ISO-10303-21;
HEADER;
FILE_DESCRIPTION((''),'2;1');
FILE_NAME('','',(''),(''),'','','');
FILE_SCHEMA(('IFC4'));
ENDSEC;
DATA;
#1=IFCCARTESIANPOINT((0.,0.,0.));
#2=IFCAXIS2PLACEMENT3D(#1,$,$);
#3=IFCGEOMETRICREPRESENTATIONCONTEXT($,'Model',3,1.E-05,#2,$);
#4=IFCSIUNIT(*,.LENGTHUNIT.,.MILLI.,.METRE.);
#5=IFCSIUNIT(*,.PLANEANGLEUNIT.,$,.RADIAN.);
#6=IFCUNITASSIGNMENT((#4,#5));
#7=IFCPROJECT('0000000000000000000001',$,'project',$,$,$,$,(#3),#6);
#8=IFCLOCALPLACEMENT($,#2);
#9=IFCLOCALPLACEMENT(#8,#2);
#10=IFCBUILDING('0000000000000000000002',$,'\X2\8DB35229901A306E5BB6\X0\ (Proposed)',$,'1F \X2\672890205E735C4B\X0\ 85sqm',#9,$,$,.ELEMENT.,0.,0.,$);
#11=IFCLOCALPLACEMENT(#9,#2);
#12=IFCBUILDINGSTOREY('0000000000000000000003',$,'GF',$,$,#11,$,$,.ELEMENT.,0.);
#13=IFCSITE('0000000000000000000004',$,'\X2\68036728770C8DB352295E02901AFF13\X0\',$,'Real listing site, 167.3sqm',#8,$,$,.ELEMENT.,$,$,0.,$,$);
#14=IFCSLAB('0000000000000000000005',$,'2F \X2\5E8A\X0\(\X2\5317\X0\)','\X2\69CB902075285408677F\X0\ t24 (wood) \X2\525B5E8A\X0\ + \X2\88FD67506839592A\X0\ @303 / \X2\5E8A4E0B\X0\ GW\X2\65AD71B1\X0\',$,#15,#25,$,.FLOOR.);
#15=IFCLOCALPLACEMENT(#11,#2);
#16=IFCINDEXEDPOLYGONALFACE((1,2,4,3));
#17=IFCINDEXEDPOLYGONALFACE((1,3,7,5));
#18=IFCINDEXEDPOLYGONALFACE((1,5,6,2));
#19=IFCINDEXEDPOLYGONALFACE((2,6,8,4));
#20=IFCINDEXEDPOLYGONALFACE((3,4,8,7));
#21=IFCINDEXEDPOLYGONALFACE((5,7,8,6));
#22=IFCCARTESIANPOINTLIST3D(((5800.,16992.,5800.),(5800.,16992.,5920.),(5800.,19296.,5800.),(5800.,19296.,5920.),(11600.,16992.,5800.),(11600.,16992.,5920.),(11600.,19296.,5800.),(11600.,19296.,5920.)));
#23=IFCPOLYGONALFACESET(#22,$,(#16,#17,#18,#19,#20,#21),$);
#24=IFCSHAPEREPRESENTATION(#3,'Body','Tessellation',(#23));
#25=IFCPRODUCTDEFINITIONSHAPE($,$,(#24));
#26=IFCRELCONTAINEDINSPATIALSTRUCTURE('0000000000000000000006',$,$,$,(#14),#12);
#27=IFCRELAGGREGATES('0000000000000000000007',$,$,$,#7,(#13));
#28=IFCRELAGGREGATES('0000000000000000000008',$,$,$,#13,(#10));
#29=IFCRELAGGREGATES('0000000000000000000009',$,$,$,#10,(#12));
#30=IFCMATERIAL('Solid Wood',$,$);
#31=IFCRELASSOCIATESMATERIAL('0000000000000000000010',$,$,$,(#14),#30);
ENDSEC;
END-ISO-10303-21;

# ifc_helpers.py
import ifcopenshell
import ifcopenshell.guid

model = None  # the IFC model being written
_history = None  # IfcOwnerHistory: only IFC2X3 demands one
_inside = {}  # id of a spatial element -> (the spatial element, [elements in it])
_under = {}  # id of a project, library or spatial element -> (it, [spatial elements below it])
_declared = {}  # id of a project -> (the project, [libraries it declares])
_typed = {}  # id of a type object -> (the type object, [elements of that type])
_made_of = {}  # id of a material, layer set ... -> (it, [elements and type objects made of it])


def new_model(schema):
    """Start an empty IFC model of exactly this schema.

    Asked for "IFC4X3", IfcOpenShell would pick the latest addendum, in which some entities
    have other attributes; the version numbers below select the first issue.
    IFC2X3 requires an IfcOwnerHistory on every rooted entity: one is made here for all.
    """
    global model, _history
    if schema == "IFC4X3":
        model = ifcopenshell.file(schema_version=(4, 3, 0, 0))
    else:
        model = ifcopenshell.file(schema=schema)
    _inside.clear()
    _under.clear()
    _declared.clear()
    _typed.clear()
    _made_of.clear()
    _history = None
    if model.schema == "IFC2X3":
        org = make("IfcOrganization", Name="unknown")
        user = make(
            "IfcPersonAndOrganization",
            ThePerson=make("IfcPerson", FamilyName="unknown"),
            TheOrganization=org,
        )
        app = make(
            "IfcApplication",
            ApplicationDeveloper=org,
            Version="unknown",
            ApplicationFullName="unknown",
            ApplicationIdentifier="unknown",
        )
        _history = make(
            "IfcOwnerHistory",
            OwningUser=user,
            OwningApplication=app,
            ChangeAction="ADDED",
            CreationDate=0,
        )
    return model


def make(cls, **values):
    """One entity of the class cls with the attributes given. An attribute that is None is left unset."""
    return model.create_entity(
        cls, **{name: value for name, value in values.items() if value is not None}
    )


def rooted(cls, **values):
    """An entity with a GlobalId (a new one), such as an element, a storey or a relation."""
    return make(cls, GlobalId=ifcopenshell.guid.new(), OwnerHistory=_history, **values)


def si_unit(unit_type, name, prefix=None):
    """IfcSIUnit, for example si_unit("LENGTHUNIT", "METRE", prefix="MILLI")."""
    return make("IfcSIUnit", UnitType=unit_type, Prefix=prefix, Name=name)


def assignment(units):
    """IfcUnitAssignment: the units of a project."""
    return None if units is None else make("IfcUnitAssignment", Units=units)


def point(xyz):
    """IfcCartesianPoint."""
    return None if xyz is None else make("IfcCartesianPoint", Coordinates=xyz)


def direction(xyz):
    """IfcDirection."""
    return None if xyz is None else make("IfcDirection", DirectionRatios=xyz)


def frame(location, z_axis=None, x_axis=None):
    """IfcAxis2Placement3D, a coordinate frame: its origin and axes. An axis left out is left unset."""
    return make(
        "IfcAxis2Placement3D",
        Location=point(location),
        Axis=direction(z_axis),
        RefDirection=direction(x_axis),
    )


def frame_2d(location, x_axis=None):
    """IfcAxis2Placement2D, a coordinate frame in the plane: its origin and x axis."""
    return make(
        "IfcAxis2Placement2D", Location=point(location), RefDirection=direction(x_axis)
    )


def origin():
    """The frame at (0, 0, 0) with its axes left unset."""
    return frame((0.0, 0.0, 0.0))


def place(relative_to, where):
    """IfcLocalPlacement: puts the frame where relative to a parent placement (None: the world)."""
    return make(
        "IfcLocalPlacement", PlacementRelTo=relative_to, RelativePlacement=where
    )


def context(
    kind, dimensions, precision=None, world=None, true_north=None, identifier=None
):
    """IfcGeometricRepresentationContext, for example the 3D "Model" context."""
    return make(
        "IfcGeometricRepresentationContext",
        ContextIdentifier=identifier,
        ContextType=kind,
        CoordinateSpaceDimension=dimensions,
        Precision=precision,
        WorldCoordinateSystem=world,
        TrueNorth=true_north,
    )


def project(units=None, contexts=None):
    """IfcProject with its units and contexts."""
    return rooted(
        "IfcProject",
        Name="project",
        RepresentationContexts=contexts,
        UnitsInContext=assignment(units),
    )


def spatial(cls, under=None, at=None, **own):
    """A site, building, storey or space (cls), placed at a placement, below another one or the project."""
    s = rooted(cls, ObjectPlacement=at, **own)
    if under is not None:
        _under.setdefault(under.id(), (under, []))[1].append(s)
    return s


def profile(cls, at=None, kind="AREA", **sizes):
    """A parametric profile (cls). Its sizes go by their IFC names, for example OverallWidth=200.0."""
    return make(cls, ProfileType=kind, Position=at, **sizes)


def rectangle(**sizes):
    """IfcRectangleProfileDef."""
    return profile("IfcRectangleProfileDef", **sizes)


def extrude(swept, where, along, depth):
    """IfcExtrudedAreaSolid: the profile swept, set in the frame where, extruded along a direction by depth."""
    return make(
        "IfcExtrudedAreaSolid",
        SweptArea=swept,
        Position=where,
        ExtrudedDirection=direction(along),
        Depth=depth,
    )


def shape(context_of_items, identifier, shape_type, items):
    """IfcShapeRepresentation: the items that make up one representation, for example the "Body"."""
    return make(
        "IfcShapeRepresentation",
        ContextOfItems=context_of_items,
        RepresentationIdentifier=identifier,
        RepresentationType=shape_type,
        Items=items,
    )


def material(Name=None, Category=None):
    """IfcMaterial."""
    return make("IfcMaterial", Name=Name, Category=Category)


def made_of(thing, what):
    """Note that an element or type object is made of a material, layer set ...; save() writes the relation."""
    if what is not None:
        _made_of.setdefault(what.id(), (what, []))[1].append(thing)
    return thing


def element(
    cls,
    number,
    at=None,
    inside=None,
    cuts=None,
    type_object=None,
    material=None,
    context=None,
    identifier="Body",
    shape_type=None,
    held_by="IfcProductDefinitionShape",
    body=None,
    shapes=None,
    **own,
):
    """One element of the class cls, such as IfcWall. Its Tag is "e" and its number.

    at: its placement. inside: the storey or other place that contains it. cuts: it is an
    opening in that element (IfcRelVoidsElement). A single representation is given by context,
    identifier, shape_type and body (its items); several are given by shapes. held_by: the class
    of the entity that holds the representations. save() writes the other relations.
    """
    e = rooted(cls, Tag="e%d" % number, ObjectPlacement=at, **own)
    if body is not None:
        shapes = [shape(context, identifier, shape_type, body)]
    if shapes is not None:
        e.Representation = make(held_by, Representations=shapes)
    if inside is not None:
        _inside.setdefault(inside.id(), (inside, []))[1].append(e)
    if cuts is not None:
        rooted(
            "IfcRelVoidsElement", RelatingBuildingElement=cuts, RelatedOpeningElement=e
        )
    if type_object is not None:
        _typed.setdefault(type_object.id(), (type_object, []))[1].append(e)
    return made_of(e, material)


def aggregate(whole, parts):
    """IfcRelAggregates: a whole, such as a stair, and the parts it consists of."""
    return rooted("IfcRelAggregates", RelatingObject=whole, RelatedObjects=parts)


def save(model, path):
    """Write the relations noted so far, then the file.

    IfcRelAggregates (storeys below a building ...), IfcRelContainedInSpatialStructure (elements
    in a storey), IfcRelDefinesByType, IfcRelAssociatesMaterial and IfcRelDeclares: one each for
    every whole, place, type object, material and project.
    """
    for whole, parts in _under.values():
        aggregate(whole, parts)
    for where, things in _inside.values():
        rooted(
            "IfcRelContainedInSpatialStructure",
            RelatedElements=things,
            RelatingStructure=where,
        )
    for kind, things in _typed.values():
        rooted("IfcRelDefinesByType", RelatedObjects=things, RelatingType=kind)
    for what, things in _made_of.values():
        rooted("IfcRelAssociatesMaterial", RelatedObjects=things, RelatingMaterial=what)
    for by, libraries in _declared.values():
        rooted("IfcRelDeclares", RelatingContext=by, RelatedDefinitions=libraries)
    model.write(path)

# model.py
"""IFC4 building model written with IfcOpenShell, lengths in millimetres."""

from ifc_helpers import new_model, si_unit, frame, frame_2d, origin, place, context, project, spatial, rectangle, extrude, material, element, save


model = new_model("IFC4")

# Units and contexts
model_context = context("Model", 3, precision=1e-05, world=origin())
ifc_project = project(units=[si_unit("LENGTHUNIT", "METRE", prefix="MILLI"), si_unit("PLANEANGLEUNIT", "RADIAN")], contexts=[model_context])

# Site, building, storey
site_placement = place(None, origin())
site = spatial("IfcSite", under=ifc_project, at=site_placement, Name="栃木県足利市通３", ObjectType="Real listing site, 167.3sqm", CompositionType="ELEMENT", RefElevation=0.0)
building_placement = place(site_placement, origin())
building = spatial("IfcBuilding", under=site, at=building_placement, Name="足利通の家 (Proposed)", ObjectType="1F 木造平屋 85sqm", CompositionType="ELEMENT", ElevationOfRefHeight=0.0, ElevationOfTerrain=0.0)
storey_placement = place(building_placement, origin())
storey = spatial("IfcBuildingStorey", under=building, at=storey_placement, Name="GF", CompositionType="ELEMENT", Elevation=0.0)

# Slab
ifc_material_1 = material(Name="Solid Wood")
slab_placement = place(storey_placement, frame((2900.0, 8496.0, 2900.0)))
element("IfcSlab", 1, at=slab_placement, inside=storey, material=ifc_material_1, Name="2F 床(北)", Description="構造用合板 t24 (wood) 剛床 + 製材根太 @303 / 床下 GW断熱", PredefinedType="FLOOR", context=model_context, shape_type="SweptSolid", body=[
    extrude(rectangle(XDim=5800.0, YDim=2304.0, at=frame_2d((2900.0, 1152.0))), frame((2900.0, 8496.0, 2900.0)), (0.0, 0.0, 1.0), 120.0),
])

save(model, "model.ifc")
